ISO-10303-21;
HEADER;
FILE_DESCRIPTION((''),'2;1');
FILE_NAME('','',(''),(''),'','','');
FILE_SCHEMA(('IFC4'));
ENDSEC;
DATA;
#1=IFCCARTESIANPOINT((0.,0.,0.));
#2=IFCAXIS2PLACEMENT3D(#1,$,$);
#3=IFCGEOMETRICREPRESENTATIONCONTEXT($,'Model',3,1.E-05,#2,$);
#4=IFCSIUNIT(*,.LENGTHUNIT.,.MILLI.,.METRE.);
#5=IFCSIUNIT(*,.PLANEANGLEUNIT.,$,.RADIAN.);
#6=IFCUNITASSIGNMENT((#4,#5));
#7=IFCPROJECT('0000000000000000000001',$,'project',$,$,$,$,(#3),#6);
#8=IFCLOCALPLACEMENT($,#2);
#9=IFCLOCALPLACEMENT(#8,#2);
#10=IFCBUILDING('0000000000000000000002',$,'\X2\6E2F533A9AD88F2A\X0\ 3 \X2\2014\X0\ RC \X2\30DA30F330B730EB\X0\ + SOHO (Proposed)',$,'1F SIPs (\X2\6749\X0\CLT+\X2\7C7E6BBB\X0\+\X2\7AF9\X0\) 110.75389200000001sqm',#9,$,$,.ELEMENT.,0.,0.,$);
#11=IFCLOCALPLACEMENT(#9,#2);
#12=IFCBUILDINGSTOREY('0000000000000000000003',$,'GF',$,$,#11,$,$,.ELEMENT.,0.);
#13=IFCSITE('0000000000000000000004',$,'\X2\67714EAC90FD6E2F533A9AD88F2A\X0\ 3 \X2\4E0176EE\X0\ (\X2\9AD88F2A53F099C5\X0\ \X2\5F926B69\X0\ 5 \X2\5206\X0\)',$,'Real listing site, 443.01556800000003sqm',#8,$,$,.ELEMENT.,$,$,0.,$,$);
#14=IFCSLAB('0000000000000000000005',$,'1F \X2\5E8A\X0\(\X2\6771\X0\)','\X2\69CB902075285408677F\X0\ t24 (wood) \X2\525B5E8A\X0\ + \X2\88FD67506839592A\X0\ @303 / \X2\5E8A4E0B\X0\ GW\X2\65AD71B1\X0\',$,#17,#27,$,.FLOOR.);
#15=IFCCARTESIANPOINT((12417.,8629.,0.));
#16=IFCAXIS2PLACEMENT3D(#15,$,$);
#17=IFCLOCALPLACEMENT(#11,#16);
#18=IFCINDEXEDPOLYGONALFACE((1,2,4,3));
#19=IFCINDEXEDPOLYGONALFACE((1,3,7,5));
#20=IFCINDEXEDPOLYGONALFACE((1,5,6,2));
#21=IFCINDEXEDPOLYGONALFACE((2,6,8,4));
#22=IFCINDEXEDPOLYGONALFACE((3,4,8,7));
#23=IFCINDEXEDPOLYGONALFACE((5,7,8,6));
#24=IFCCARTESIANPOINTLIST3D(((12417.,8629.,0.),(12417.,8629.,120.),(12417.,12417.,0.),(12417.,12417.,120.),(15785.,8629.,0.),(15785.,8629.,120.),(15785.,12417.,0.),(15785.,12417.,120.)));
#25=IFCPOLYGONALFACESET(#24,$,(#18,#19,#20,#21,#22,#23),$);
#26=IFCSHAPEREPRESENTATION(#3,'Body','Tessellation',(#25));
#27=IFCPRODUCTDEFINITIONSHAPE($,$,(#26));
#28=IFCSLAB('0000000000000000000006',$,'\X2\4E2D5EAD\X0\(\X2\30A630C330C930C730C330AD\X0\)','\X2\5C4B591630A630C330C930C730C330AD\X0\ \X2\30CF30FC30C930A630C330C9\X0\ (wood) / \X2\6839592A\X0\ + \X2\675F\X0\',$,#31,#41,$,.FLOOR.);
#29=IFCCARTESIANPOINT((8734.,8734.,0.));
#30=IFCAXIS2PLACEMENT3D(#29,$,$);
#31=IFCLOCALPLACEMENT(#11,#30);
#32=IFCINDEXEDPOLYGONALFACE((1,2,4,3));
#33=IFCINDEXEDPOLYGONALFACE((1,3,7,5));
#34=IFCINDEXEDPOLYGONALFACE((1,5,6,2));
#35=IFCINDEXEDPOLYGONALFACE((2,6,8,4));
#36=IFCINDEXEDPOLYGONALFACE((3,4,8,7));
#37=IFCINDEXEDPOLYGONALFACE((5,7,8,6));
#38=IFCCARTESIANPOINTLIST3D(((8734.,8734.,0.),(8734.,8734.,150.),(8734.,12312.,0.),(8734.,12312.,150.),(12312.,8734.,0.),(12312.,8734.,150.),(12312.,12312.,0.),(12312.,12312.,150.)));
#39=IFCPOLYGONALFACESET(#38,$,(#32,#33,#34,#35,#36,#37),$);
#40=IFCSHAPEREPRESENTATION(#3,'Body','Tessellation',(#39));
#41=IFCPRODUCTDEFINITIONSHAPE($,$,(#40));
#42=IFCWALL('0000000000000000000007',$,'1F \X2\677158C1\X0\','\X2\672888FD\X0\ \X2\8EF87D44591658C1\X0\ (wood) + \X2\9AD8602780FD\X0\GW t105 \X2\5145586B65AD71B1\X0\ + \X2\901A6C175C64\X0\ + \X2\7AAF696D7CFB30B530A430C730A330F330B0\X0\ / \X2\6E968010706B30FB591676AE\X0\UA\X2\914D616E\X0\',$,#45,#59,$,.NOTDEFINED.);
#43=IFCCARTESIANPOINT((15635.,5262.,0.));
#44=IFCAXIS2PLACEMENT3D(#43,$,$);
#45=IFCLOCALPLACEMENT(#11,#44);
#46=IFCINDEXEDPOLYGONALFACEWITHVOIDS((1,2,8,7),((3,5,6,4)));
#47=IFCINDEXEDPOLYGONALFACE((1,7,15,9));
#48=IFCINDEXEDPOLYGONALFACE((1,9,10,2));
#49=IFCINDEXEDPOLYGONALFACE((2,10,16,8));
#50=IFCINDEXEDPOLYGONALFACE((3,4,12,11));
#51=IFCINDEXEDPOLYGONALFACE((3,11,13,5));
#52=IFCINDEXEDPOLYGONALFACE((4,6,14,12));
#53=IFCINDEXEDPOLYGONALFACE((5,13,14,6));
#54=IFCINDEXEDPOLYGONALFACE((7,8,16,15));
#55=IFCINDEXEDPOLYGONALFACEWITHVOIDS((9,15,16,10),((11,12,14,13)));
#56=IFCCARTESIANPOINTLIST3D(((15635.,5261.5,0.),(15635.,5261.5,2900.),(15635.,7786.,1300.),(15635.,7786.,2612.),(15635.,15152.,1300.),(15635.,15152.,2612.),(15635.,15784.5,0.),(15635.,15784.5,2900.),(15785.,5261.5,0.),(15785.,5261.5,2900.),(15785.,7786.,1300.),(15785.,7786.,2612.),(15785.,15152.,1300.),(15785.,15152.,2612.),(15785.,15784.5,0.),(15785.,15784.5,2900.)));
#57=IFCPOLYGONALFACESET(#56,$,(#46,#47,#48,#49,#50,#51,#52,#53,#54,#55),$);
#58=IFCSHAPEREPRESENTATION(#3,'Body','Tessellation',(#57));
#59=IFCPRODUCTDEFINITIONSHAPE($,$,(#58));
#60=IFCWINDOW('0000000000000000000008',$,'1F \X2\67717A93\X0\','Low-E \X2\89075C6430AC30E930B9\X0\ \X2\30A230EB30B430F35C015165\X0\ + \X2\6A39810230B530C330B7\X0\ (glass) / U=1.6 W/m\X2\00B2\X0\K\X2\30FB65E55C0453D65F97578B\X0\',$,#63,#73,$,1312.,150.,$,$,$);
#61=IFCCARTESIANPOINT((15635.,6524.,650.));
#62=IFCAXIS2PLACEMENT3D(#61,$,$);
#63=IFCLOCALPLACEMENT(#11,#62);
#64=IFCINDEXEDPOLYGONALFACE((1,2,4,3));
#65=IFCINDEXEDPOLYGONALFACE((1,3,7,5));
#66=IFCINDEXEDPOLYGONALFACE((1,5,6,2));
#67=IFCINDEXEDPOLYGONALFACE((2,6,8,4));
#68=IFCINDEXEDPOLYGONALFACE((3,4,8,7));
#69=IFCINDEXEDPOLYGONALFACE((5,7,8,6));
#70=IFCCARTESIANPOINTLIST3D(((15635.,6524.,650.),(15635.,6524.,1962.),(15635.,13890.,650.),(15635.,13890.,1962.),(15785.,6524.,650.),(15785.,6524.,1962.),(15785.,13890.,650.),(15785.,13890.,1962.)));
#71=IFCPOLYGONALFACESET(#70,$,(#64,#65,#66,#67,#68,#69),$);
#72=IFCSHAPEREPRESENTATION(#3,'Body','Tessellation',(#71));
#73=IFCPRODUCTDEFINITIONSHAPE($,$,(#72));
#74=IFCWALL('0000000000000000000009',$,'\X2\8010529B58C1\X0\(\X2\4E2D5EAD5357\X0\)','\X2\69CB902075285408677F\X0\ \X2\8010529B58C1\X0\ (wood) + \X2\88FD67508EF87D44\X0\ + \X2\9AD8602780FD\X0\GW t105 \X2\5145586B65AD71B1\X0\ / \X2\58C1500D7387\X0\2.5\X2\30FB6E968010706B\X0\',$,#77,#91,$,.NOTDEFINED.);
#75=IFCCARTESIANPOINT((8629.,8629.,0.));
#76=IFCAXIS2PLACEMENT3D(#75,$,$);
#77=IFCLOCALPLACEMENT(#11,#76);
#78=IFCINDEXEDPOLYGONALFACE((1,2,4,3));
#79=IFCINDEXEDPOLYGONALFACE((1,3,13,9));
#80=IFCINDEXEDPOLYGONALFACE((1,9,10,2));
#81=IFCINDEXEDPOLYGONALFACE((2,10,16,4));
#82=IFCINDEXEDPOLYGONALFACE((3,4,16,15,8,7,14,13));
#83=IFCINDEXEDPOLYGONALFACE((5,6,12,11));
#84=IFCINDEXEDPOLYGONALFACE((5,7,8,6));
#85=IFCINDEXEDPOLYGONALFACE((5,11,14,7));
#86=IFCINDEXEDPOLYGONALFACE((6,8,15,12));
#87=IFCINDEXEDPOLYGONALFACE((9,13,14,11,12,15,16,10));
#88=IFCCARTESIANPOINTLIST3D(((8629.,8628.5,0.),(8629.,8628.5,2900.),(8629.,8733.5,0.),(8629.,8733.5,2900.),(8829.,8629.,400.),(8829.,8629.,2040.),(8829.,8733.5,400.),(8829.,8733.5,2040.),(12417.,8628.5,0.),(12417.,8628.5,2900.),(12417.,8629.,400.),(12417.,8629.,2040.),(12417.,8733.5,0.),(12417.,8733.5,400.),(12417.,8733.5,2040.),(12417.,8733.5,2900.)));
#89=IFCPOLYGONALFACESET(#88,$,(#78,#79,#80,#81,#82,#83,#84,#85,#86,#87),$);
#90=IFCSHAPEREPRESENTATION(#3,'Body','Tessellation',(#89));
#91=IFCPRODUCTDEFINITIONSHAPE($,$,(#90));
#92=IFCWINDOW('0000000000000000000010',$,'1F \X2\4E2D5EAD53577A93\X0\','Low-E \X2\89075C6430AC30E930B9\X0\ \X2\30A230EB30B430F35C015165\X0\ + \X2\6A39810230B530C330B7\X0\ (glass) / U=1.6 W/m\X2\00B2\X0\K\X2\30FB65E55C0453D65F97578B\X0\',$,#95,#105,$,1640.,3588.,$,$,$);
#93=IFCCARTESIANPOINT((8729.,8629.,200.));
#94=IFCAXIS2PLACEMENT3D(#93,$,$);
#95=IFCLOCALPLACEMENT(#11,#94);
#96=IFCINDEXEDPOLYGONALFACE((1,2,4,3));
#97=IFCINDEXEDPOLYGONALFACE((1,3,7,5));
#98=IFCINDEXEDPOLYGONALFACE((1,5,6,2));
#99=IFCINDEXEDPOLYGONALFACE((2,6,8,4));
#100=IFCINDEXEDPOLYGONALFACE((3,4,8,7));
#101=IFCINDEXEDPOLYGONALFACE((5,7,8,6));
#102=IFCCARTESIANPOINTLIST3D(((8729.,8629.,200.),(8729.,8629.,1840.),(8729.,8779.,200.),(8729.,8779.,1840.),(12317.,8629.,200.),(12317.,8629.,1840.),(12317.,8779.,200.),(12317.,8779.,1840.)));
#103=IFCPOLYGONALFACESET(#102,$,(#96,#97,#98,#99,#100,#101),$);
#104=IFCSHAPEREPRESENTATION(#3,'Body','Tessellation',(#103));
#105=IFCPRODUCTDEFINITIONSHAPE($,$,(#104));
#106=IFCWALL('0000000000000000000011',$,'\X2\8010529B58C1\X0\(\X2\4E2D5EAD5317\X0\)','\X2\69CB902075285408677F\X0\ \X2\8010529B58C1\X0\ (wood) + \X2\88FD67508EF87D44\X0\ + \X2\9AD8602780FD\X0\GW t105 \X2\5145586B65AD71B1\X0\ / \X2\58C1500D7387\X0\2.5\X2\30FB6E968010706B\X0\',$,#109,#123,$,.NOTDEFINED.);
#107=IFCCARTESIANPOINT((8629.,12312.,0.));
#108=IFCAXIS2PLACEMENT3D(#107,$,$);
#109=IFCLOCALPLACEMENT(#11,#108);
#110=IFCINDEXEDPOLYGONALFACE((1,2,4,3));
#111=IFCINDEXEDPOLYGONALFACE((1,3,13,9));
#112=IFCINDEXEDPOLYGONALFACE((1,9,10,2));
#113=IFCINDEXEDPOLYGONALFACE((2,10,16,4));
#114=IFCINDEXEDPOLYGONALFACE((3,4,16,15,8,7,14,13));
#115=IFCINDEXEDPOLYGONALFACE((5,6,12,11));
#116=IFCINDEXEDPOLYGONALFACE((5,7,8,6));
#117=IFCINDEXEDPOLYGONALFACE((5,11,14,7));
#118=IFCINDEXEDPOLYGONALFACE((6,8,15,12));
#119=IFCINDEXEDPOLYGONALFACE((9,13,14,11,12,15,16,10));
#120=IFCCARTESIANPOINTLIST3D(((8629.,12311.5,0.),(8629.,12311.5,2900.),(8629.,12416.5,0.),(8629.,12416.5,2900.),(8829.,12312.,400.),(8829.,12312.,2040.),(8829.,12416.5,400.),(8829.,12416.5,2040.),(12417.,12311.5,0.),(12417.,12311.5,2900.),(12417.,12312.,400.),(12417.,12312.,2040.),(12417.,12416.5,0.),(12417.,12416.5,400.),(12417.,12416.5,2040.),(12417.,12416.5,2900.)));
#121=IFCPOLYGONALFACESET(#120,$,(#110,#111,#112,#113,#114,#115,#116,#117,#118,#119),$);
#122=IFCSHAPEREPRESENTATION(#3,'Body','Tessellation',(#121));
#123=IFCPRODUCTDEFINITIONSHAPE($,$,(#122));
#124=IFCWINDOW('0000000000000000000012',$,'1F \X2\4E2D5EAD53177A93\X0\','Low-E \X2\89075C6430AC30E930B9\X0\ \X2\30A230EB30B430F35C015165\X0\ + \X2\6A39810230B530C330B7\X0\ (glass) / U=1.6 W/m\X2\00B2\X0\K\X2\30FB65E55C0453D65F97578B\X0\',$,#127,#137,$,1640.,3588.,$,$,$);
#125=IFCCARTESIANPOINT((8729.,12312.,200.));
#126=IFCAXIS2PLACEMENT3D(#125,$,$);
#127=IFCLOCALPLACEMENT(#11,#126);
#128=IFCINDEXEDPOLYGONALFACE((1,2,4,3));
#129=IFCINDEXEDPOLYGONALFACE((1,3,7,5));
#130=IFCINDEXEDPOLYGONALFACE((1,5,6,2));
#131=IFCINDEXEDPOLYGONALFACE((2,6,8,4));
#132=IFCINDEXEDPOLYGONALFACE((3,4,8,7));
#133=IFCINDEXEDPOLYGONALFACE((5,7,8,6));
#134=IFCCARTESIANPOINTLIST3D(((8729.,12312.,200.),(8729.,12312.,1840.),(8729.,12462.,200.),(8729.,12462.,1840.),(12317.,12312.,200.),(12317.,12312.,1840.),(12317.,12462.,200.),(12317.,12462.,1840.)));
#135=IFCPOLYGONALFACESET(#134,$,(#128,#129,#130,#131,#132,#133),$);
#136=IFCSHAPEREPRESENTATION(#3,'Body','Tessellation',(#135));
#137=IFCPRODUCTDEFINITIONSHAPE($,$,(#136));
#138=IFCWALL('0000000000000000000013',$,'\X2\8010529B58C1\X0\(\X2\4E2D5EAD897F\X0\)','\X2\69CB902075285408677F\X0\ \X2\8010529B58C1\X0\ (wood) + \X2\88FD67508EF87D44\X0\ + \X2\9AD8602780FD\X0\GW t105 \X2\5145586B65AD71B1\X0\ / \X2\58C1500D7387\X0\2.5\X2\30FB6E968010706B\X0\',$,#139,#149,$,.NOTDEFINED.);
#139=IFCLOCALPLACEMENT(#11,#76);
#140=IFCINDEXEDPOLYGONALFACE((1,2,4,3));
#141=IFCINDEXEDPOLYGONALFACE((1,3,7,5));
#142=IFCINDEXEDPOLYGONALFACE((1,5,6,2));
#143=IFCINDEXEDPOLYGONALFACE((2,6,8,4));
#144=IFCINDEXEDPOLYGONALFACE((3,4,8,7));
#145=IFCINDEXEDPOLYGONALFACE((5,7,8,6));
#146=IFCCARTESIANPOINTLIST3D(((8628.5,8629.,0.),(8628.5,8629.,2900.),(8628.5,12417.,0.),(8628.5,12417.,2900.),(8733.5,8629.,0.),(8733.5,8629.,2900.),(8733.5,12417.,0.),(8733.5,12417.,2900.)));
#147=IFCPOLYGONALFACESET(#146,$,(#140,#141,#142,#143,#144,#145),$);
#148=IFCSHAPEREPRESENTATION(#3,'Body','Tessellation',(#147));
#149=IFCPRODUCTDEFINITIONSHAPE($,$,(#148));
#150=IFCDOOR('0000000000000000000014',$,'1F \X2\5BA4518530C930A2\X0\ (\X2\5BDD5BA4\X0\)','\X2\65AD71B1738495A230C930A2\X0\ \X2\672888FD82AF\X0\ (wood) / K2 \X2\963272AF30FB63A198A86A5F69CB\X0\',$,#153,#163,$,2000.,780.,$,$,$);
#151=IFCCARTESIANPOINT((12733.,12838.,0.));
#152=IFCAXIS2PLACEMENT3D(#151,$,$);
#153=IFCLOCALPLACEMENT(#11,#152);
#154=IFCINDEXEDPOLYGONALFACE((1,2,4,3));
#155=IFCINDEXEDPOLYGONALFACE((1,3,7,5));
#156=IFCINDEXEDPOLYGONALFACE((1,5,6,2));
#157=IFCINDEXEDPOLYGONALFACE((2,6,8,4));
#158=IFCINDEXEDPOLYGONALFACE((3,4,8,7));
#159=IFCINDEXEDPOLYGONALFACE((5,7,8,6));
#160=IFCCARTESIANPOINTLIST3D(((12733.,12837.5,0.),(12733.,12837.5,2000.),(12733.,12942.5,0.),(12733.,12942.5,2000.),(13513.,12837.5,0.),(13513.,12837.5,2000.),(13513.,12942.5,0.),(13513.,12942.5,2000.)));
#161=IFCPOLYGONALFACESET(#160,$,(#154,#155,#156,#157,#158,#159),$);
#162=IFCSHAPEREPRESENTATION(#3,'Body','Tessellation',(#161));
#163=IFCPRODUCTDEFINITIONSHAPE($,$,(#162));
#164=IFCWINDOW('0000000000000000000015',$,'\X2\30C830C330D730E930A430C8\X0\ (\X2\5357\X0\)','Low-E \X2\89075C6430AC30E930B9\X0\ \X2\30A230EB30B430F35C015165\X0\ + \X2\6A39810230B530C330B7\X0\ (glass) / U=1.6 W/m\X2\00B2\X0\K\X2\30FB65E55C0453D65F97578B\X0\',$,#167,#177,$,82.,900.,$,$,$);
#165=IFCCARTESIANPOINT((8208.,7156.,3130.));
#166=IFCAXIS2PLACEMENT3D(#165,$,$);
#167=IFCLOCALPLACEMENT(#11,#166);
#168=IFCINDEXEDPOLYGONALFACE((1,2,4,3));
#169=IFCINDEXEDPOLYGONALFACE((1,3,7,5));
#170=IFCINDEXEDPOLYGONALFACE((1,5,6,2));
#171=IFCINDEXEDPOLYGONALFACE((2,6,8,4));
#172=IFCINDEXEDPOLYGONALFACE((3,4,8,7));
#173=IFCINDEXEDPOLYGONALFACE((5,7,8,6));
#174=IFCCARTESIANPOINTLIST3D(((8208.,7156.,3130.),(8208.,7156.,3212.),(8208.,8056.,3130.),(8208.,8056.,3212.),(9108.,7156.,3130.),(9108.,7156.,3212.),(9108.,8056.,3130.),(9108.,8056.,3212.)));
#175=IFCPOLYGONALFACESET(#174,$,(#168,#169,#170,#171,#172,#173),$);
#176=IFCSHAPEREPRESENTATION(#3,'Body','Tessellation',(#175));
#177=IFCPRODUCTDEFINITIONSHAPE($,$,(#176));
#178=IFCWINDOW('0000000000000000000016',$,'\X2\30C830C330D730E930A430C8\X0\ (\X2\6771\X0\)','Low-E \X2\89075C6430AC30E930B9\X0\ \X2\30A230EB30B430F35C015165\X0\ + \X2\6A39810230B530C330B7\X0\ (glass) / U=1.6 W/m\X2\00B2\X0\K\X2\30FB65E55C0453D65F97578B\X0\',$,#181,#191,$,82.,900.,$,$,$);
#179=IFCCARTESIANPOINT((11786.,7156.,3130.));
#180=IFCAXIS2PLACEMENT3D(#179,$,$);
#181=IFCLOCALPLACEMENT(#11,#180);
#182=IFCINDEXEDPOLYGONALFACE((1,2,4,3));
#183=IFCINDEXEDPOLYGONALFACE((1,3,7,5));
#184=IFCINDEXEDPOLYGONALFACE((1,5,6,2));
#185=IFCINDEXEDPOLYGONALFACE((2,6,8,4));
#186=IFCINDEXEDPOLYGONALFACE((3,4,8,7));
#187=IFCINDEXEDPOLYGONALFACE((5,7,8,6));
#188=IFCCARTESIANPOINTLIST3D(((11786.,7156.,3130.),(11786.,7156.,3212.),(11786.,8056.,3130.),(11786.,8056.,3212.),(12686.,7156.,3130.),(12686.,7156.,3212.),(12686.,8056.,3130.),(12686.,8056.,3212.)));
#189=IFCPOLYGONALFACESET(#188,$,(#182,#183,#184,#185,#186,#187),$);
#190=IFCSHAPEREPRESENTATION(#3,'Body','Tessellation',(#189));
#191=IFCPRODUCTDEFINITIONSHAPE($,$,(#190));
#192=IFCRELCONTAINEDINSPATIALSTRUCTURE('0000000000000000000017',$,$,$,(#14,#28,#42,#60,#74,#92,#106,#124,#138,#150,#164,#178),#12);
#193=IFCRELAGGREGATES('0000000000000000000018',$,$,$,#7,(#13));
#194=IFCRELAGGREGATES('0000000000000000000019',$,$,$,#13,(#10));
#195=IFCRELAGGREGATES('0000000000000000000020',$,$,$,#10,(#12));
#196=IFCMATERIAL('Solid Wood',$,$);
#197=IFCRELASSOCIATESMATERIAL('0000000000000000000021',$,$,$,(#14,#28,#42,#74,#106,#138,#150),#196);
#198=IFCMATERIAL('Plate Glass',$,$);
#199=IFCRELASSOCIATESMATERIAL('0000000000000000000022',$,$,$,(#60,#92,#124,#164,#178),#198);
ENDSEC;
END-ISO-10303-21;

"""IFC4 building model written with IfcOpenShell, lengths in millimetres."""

from ifc_helpers import new_model, si_unit, frame, frame_2d, origin, place, context, project, spatial, rectangle, extrude, material, element, fill, save


model = new_model("IFC4")

# Units and contexts
model_context = context("Model", 3, precision=1e-05, world=origin())
ifc_project = project(units=[si_unit("LENGTHUNIT", "METRE", prefix="MILLI"), si_unit("PLANEANGLEUNIT", "RADIAN")], contexts=[model_context])

# Site, building, storey
site_placement = place(None, origin())
site = spatial("IfcSite", under=ifc_project, at=site_placement, Name="東京都港区高輪 3 丁目 (高輪台駅 徒歩 5 分)", ObjectType="Real listing site, 443.01556800000003sqm", CompositionType="ELEMENT", RefElevation=0.0)
building_placement = place(site_placement, origin())
building = spatial("IfcBuilding", under=site, at=building_placement, Name="港区高輪 3 — RC ペンシル + SOHO (Proposed)", ObjectType="1F SIPs (杉CLT+籾殻+竹) 110.75389200000001sqm", CompositionType="ELEMENT", ElevationOfRefHeight=0.0, ElevationOfTerrain=0.0)
storey_placement = place(building_placement, origin())
storey = spatial("IfcBuildingStorey", under=building, at=storey_placement, Name="GF", CompositionType="ELEMENT", Elevation=0.0)

# Slabs
ifc_material_1 = material(Name="Solid Wood")
slab_1_placement = place(storey_placement, frame((12417.0, 8629.0, 0.0)))
element("IfcSlab", 1, at=slab_1_placement, inside=storey, material=ifc_material_1, Name="1F 床(東)", Description="構造用合板 t24 (wood) 剛床 + 製材根太 @303 / 床下 GW断熱", PredefinedType="FLOOR", context=model_context, shape_type="SweptSolid", body=[
    extrude(rectangle(XDim=3368.0, YDim=3788.0, at=frame_2d((1684.0, 1894.0))), frame((12417.0, 8629.0, 0.0)), (0.0, 0.0, 1.0), 120.0),
])
slab_2_placement = place(storey_placement, frame((8734.0, 8734.0, 0.0)))
element("IfcSlab", 2, at=slab_2_placement, inside=storey, material=ifc_material_1, Name="中庭(ウッドデッキ)", Description="屋外ウッドデッキ ハードウッド (wood) / 根太 + 束", PredefinedType="FLOOR", context=model_context, shape_type="SweptSolid", body=[
    extrude(rectangle(XDim=3578.0, YDim=3578.0, at=frame_2d((1789.0, 1789.0))), frame((8734.0, 8734.0, 0.0)), (0.0, 0.0, 1.0), 150.0),
])

# Walls, openings, windows
wall_1_placement = place(storey_placement, frame((15635.0, 5262.0, 0.0)))
wall_1 = element("IfcWall", 3, at=wall_1_placement, inside=storey, material=ifc_material_1, Name="1F 東壁", Description="木製 軸組外壁 (wood) + 高性能GW t105 充填断熱 + 通気層 + 窯業系サイディング / 準耐火・外皮UA配慮", PredefinedType="NOTDEFINED", context=model_context, shape_type="SweptSolid", body=[
    extrude(rectangle(XDim=150.0, YDim=10523.0, at=frame_2d((75.0, 5261.0))), frame((15635.0, 5262.0, 0.0)), (0.0, 0.0, 1.0), 2900.0),
])
opening_1_placement = place(storey_placement, frame((15635.0, 6524.0, 650.0)))
opening_1 = element("IfcOpeningElement", 4, at=opening_1_placement, cuts=wall_1, PredefinedType="NOTDEFINED", context=model_context, shape_type="SweptSolid", body=[
    extrude(rectangle(XDim=150.0, YDim=7366.0, at=frame_2d((75.0, 3683.0))), frame((15635.0, 6524.0, 650.0)), (0.0, 0.0, 1.0), 1312.0),
])
ifc_material_2 = material(Name="Plate Glass")
window_1_placement = place(storey_placement, frame((15635.0, 6524.0, 650.0)))
window_1 = element("IfcWindow", 5, at=window_1_placement, inside=storey, material=ifc_material_2, Name="1F 東窓", Description="Low-E 複層ガラス アルゴン封入 + 樹脂サッシ (glass) / U=1.6 W/m²K・日射取得型", OverallHeight=1312.0, OverallWidth=150.0, context=model_context, shape_type="SweptSolid", body=[
    extrude(rectangle(XDim=150.0, YDim=7366.0, at=frame_2d((75.0, 3683.0))), frame((15635.0, 6524.0, 650.0)), (0.0, 0.0, 1.0), 1312.0),
])
fill(opening_1, window_1)
wall_2_placement = place(storey_placement, frame((8629.0, 8629.0, 0.0)))
wall_2 = element("IfcWall", 6, at=wall_2_placement, inside=storey, material=ifc_material_1, Name="耐力壁(中庭南)", Description="構造用合板 耐力壁 (wood) + 製材軸組 + 高性能GW t105 充填断熱 / 壁倍率2.5・準耐火", PredefinedType="NOTDEFINED", context=model_context, shape_type="SweptSolid", body=[
    extrude(rectangle(XDim=3788.0, YDim=105.0, at=frame_2d((1894.0, 52.0))), frame((8629.0, 8629.0, 0.0)), (0.0, 0.0, 1.0), 2900.0),
])
opening_2_placement = place(storey_placement, frame((8729.0, 8629.0, 200.0)))
opening_2 = element("IfcOpeningElement", 7, at=opening_2_placement, cuts=wall_2, PredefinedType="NOTDEFINED", context=model_context, shape_type="SweptSolid", body=[
    extrude(rectangle(XDim=3588.0, YDim=150.0, at=frame_2d((1794.0, 75.0))), frame((8729.0, 8629.0, 200.0)), (0.0, 0.0, 1.0), 1640.0),
])
window_2_placement = place(storey_placement, frame((8729.0, 8629.0, 200.0)))
window_2 = element("IfcWindow", 8, at=window_2_placement, inside=storey, material=ifc_material_2, Name="1F 中庭南窓", Description="Low-E 複層ガラス アルゴン封入 + 樹脂サッシ (glass) / U=1.6 W/m²K・日射取得型", OverallHeight=1640.0, OverallWidth=3588.0, context=model_context, shape_type="SweptSolid", body=[
    extrude(rectangle(XDim=3588.0, YDim=150.0, at=frame_2d((1794.0, 75.0))), frame((8729.0, 8629.0, 200.0)), (0.0, 0.0, 1.0), 1640.0),
])
fill(opening_2, window_2)
wall_3_placement = place(storey_placement, frame((8629.0, 12312.0, 0.0)))
wall_3 = element("IfcWall", 9, at=wall_3_placement, inside=storey, material=ifc_material_1, Name="耐力壁(中庭北)", Description="構造用合板 耐力壁 (wood) + 製材軸組 + 高性能GW t105 充填断熱 / 壁倍率2.5・準耐火", PredefinedType="NOTDEFINED", context=model_context, shape_type="SweptSolid", body=[
    extrude(rectangle(XDim=3788.0, YDim=105.0, at=frame_2d((1894.0, 52.0))), frame((8629.0, 12312.0, 0.0)), (0.0, 0.0, 1.0), 2900.0),
])
opening_3_placement = place(storey_placement, frame((8729.0, 12312.0, 200.0)))
opening_3 = element("IfcOpeningElement", 10, at=opening_3_placement, cuts=wall_3, PredefinedType="NOTDEFINED", context=model_context, shape_type="SweptSolid", body=[
    extrude(rectangle(XDim=3588.0, YDim=150.0, at=frame_2d((1794.0, 75.0))), frame((8729.0, 12312.0, 200.0)), (0.0, 0.0, 1.0), 1640.0),
])
window_3_placement = place(storey_placement, frame((8729.0, 12312.0, 200.0)))
window_3 = element("IfcWindow", 11, at=window_3_placement, inside=storey, material=ifc_material_2, Name="1F 中庭北窓", Description="Low-E 複層ガラス アルゴン封入 + 樹脂サッシ (glass) / U=1.6 W/m²K・日射取得型", OverallHeight=1640.0, OverallWidth=3588.0, context=model_context, shape_type="SweptSolid", body=[
    extrude(rectangle(XDim=3588.0, YDim=150.0, at=frame_2d((1794.0, 75.0))), frame((8729.0, 12312.0, 200.0)), (0.0, 0.0, 1.0), 1640.0),
])
fill(opening_3, window_3)

# Wall
wall_4_placement = place(storey_placement, frame((8629.0, 8629.0, 0.0)))
element("IfcWall", 12, at=wall_4_placement, inside=storey, material=ifc_material_1, Name="耐力壁(中庭西)", Description="構造用合板 耐力壁 (wood) + 製材軸組 + 高性能GW t105 充填断熱 / 壁倍率2.5・準耐火", PredefinedType="NOTDEFINED", context=model_context, shape_type="SweptSolid", body=[
    extrude(rectangle(XDim=105.0, YDim=3788.0, at=frame_2d((52.0, 1894.0))), frame((8629.0, 8629.0, 0.0)), (0.0, 0.0, 1.0), 2900.0),
])

# Door
door_placement = place(storey_placement, frame((12733.0, 12838.0, 0.0)))
element("IfcDoor", 13, at=door_placement, inside=storey, material=ifc_material_1, Name="1F 室内ドア (寝室)", Description="断熱玄関ドア 木製芯 (wood) / K2 防犯・採風機構", OverallHeight=2000.0, OverallWidth=780.0, context=model_context, shape_type="SweptSolid", body=[
    extrude(rectangle(XDim=780.0, YDim=105.0, at=frame_2d((390.0, 52.0))), frame((12733.0, 12838.0, 0.0)), (0.0, 0.0, 1.0), 2000.0),
])

# Windows
window_4_placement = place(storey_placement, frame((8208.0, 7156.0, 3130.0)))
element("IfcWindow", 14, at=window_4_placement, inside=storey, material=ifc_material_2, Name="トップライト (南)", Description="Low-E 複層ガラス アルゴン封入 + 樹脂サッシ (glass) / U=1.6 W/m²K・日射取得型", OverallHeight=82.0, OverallWidth=900.0, context=model_context, shape_type="SweptSolid", body=[
    extrude(rectangle(XDim=900.0, YDim=900.0, at=frame_2d((450.0, 450.0))), frame((8208.0, 7156.0, 3130.0)), (0.0, 0.0, 1.0), 82.0),
])
window_5_placement = place(storey_placement, frame((11786.0, 7156.0, 3130.0)))
element("IfcWindow", 15, at=window_5_placement, inside=storey, material=ifc_material_2, Name="トップライト (東)", Description="Low-E 複層ガラス アルゴン封入 + 樹脂サッシ (glass) / U=1.6 W/m²K・日射取得型", OverallHeight=82.0, OverallWidth=900.0, context=model_context, shape_type="SweptSolid", body=[
    extrude(rectangle(XDim=900.0, YDim=900.0, at=frame_2d((450.0, 450.0))), frame((11786.0, 7156.0, 3130.0)), (0.0, 0.0, 1.0), 82.0),
])

save(model, "model.ifc")
